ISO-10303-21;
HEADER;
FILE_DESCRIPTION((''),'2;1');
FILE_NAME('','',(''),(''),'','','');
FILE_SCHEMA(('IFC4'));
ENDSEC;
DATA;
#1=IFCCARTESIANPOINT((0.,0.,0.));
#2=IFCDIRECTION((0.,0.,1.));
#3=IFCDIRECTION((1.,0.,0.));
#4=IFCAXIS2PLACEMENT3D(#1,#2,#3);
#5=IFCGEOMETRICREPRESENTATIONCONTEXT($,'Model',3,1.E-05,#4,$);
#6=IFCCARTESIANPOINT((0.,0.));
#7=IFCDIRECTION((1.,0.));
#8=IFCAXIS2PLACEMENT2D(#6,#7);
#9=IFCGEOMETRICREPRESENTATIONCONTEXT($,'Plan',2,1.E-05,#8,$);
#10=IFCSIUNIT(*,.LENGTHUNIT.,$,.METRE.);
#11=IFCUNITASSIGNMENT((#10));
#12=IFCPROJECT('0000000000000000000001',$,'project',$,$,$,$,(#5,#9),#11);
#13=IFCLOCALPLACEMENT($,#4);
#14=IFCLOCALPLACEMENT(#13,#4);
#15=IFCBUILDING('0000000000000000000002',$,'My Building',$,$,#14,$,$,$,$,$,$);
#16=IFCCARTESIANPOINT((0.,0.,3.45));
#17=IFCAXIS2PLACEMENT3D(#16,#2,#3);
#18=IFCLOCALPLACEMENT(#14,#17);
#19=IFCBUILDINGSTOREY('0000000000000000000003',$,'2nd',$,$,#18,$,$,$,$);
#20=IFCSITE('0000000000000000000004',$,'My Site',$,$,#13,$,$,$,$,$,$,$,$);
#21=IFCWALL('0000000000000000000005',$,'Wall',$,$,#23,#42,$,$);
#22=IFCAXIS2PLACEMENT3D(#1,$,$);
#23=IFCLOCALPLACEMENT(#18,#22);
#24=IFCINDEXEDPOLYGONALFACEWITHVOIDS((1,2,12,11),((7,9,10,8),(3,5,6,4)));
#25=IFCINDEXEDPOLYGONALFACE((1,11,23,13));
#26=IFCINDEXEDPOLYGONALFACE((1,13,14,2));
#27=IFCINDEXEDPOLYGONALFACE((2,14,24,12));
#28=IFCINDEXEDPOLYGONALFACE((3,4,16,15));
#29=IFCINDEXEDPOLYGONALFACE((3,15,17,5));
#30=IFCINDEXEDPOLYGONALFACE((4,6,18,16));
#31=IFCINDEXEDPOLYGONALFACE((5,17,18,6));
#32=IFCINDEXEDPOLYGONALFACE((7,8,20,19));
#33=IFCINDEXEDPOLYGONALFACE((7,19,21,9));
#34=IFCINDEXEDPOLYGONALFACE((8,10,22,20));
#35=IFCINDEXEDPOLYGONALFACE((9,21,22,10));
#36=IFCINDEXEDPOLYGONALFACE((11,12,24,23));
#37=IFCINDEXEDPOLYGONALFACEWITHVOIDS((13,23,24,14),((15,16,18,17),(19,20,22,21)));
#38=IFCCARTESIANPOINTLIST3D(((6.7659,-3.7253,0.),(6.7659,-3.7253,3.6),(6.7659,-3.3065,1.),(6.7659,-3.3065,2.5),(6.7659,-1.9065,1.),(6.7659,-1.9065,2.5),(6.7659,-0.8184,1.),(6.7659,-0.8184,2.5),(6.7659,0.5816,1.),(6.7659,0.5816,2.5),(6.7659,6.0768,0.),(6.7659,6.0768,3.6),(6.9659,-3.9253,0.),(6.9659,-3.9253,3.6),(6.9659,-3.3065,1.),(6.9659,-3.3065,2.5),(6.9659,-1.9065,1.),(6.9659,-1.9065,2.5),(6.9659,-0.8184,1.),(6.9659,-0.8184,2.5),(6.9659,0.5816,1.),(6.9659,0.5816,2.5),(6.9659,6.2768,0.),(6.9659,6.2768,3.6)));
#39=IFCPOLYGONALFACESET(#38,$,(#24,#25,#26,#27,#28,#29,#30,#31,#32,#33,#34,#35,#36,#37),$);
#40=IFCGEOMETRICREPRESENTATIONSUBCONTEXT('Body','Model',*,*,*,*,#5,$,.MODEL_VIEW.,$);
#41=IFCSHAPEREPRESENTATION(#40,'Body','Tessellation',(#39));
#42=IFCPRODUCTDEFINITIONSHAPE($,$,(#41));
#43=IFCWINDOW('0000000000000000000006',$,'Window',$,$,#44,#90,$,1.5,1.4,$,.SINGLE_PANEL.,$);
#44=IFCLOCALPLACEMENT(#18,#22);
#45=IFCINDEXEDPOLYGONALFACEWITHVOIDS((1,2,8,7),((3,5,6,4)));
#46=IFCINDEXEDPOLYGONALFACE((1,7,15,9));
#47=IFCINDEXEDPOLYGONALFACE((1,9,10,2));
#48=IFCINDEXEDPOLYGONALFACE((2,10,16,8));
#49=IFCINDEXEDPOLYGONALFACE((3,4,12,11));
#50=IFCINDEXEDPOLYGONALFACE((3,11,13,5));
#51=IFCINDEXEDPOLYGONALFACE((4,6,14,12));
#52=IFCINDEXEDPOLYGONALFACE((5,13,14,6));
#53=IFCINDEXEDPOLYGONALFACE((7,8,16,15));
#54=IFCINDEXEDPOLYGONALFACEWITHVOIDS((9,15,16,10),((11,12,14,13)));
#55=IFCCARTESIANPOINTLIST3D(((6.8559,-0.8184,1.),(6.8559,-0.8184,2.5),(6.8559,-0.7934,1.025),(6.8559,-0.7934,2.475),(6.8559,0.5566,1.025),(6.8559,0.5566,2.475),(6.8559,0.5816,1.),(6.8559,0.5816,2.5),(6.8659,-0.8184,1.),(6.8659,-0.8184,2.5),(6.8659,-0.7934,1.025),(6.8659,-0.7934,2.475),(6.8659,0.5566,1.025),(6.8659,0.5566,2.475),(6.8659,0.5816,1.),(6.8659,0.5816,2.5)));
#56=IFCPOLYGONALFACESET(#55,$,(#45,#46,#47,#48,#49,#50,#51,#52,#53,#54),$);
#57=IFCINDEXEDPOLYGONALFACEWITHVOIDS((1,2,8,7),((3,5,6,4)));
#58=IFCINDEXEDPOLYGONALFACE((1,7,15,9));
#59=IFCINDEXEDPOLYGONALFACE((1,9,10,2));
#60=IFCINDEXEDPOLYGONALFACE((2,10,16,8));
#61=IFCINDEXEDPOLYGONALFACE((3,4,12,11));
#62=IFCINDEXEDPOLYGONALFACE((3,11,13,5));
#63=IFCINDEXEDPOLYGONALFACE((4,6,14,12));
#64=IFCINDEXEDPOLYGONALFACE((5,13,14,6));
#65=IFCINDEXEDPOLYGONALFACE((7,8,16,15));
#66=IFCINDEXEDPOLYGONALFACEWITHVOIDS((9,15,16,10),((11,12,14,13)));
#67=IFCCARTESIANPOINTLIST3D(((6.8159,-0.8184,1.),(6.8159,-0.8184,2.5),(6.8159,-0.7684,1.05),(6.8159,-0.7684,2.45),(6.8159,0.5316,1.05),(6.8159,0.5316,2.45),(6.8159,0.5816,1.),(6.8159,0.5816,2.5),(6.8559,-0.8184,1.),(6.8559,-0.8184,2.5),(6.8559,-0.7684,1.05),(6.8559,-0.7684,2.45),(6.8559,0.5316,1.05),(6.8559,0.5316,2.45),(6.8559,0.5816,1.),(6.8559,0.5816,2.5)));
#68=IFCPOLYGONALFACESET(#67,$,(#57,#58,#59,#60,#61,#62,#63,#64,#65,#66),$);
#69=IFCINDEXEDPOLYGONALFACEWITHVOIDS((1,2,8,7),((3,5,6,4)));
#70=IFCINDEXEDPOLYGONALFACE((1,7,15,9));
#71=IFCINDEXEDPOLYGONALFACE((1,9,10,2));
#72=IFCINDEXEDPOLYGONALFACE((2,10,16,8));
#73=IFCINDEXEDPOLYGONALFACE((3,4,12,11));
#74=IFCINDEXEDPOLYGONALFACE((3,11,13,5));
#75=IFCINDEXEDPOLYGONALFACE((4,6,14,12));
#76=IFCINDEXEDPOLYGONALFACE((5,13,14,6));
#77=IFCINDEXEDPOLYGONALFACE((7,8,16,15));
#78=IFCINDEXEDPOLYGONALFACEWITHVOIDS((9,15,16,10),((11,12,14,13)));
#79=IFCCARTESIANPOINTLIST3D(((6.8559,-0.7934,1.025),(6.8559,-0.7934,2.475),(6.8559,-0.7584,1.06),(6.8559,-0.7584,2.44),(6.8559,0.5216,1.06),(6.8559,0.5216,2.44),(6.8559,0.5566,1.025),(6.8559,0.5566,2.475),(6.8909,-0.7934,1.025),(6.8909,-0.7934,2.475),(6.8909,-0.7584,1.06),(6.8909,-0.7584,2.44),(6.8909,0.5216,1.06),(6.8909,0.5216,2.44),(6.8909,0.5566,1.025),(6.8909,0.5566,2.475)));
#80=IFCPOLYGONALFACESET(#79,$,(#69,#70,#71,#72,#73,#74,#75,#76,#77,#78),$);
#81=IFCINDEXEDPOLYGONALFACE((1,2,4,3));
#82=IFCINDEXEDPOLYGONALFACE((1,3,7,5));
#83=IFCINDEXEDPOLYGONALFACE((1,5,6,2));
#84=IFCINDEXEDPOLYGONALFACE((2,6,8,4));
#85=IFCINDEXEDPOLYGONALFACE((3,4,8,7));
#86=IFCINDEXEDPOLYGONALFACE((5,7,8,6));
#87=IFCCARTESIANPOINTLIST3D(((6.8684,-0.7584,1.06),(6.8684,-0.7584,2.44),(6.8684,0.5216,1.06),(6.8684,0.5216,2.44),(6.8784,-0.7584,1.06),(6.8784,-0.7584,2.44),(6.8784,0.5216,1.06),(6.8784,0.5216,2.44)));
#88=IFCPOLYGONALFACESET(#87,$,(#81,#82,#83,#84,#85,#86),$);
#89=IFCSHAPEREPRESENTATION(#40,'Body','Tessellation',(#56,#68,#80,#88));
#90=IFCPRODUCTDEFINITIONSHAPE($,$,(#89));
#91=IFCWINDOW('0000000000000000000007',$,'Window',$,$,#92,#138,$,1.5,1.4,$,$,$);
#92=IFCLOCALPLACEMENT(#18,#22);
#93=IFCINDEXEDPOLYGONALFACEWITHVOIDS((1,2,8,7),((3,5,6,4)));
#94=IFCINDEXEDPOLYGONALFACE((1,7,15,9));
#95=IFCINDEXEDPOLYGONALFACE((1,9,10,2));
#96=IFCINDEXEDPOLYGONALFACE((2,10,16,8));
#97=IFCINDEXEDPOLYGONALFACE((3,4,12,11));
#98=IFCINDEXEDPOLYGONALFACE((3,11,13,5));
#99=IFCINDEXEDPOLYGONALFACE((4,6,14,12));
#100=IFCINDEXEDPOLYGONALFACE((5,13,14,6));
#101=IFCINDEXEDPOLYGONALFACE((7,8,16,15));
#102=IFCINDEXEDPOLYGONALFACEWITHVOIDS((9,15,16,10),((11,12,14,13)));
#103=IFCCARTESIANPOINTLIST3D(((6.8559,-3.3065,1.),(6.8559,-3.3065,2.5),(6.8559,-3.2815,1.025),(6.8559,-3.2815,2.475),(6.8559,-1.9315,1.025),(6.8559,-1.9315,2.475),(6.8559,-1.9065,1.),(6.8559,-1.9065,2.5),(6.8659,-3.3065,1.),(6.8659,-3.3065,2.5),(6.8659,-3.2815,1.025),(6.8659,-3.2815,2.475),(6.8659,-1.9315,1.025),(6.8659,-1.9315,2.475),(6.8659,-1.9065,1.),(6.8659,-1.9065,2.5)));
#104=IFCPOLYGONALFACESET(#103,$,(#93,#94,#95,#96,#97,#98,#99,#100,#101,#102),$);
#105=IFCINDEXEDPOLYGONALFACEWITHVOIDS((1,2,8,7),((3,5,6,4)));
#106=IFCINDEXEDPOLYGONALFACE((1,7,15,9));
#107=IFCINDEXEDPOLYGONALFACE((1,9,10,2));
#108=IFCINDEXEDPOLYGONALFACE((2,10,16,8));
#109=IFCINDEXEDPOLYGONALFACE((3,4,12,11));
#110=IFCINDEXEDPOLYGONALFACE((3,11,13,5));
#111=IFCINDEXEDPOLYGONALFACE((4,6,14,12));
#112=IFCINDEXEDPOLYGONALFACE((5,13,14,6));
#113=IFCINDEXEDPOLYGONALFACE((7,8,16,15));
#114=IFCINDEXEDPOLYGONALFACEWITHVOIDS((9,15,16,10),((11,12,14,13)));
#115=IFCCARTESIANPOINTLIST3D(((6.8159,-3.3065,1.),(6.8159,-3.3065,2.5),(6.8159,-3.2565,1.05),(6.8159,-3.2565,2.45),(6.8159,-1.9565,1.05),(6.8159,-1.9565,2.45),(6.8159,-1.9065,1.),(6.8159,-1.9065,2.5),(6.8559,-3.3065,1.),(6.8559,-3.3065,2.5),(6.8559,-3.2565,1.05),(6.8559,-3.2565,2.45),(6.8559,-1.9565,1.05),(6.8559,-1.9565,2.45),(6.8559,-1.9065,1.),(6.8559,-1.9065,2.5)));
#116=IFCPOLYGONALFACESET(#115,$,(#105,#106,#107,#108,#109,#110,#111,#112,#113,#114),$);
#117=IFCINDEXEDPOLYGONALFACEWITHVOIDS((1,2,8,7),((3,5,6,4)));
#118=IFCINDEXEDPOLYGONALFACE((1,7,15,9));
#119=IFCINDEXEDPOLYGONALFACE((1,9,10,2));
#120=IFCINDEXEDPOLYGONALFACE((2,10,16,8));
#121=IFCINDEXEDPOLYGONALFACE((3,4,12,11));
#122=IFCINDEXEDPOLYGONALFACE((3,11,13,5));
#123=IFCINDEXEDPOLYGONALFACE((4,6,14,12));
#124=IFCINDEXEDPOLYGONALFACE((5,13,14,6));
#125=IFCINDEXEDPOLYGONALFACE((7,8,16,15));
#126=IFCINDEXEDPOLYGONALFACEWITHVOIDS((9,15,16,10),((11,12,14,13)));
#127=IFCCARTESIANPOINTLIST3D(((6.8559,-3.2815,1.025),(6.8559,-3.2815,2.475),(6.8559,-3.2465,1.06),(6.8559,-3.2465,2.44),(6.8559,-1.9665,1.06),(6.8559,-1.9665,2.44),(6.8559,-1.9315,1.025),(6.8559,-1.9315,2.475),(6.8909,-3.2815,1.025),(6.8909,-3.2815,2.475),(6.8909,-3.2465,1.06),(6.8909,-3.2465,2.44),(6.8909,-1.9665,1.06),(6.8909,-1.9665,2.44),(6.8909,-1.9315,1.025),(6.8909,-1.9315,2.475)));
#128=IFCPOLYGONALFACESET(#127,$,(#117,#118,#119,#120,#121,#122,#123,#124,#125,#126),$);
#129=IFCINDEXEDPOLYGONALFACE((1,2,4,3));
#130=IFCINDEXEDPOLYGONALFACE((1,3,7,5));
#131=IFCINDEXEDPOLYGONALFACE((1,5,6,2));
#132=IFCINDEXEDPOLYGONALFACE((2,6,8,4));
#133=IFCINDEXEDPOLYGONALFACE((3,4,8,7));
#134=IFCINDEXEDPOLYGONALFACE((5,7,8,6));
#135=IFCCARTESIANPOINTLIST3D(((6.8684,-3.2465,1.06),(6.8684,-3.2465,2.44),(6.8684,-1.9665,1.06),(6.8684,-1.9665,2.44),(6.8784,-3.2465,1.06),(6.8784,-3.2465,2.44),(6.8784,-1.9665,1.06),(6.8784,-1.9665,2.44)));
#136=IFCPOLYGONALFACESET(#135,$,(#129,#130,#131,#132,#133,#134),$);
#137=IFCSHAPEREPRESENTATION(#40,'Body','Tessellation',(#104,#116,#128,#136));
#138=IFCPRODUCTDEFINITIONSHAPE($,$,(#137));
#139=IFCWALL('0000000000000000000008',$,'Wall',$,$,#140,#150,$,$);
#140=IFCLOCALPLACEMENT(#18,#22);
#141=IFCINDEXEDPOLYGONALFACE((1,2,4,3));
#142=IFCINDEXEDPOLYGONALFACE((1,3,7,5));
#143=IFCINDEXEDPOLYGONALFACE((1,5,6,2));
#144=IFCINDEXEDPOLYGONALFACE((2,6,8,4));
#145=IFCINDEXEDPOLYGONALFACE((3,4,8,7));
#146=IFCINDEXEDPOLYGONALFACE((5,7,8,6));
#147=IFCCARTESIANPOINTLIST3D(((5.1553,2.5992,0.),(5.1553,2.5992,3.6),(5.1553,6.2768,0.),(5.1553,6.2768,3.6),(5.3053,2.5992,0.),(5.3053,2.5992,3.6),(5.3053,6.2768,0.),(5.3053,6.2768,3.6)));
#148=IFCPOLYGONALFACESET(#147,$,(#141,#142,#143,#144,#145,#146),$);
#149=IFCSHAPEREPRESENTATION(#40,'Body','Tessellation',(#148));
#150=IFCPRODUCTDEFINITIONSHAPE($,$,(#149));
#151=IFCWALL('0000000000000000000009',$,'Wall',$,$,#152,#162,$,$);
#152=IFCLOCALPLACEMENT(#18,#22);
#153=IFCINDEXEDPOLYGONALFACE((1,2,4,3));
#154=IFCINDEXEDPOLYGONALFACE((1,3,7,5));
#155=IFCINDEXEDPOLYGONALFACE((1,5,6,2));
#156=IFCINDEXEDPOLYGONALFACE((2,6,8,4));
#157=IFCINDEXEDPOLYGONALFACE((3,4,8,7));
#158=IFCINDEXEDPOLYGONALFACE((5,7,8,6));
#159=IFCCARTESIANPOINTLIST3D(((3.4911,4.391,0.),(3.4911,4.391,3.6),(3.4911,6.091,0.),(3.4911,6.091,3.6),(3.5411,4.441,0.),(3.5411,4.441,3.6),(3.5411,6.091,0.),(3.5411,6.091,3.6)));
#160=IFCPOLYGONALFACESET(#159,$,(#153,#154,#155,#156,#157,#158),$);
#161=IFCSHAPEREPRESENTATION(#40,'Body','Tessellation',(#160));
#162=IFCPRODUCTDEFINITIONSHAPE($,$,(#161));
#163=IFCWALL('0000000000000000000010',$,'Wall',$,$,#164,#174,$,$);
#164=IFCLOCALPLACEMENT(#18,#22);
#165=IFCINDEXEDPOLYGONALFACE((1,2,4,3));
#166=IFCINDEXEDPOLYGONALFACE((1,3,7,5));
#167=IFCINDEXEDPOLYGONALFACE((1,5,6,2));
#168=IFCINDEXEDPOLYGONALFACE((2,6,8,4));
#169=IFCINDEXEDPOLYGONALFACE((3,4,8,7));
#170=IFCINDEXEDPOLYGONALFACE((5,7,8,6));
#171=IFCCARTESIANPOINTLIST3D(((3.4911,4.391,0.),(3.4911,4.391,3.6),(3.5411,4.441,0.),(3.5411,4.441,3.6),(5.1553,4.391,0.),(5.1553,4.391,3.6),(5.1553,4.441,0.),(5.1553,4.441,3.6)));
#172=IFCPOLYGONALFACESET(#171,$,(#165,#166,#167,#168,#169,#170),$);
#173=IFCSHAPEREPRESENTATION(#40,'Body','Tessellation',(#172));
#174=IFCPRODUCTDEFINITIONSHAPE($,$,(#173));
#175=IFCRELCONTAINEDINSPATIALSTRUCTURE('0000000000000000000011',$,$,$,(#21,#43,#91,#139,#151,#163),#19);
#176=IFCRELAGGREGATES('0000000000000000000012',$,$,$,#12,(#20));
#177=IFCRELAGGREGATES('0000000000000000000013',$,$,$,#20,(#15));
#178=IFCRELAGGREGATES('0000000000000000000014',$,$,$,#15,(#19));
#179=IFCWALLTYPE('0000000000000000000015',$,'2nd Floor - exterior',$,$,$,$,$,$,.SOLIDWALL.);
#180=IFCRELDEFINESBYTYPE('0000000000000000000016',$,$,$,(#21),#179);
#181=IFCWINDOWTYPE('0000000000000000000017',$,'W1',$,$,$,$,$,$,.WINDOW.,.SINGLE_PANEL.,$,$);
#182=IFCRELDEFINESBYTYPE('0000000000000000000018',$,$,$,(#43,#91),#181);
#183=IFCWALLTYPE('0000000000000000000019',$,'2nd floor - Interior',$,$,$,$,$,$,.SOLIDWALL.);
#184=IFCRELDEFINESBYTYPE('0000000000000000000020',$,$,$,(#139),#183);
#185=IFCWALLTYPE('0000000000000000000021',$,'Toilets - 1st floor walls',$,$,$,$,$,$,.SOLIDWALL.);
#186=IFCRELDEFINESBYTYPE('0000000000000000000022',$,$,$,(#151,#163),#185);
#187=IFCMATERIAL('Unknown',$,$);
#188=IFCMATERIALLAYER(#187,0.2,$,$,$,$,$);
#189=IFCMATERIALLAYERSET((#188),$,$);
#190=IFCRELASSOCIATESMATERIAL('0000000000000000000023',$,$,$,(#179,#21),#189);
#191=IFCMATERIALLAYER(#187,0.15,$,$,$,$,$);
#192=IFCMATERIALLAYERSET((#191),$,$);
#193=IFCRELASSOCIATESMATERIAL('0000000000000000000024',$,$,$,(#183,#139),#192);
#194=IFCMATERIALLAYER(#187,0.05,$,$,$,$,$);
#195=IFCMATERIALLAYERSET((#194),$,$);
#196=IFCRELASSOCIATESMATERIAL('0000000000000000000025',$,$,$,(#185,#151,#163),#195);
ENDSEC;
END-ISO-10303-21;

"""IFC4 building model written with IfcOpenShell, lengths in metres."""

from ifc_helpers import new_model, entity, si_unit, frame, origin_with_axes, origin_2d_with_axis, place, context, subcontext, project, spatial, line, indexed_curve, outline, extrude, shape, source, transform, mapped, material, layer, layer_set, layer_usage, type_object, type_shapes, element, fill, save


model = new_model("IFC4")

# Units and contexts
model_context = context("Model", 3, precision=1e-05, world=origin_with_axes())
plan_context = context("Plan", 2, precision=1e-05, world=origin_2d_with_axis())
body_context_1 = subcontext(model_context, "Body", "Model", "MODEL_VIEW")
body_context_2 = subcontext(plan_context, "Body", "Plan", "PLAN_VIEW")
ifc_project = project(units=[si_unit("LENGTHUNIT", "METRE")], contexts=[model_context, plan_context])

# Site, building, storey
site_placement = place(None, origin_with_axes())
site = spatial("IfcSite", under=ifc_project, at=site_placement, Name="My Site")
building_placement = place(site_placement, origin_with_axes())
building = spatial("IfcBuilding", under=site, at=building_placement, Name="My Building")
storey_placement = place(building_placement, frame((0.0, 0.0, 3.45), z_axis=(0.0, 0.0, 1.0), x_axis=(1.0, 0.0, 0.0)))
storey = spatial("IfcBuildingStorey", under=building, at=storey_placement, Name="2nd")

# Shared definitions
ifc_material = material(Name="Unknown")

# Shared definitions
window_type_1 = type_object("IfcWindowType", Name="W1", PartitioningType="SINGLE_PANEL", PredefinedType="WINDOW")
shared_shape_1 = source(origin_with_axes(), body_context_1, "Body", "SweptSolid", [
    extrude(outline(indexed_curve([(0.0, 0.0), (1.4, 0.0), (1.4, 1.5), (0.0, 1.5)], segments=[line(1, 2, 3, 4, 1)]), holes=[indexed_curve([(0.025, 0.025), (1.375, 0.025), (1.375, 1.475), (0.025, 1.475)], segments=[line(1, 2, 3, 4, 1)])]), frame((0.0, 0.09, 0.0), z_axis=(0.0, -1.0, 0.0), x_axis=(1.0, 0.0, 0.0)), (0.0, 0.0, -1.0), 0.01),
    extrude(outline(indexed_curve([(0.0, 0.0), (1.4, 0.0), (1.4, 1.5), (0.0, 1.5)], segments=[line(1, 2, 3, 4, 1)]), holes=[indexed_curve([(0.05, 0.05), (1.35, 0.05), (1.35, 1.45), (0.05, 1.45)], segments=[line(1, 2, 3, 4, 1)])]), frame((0.0, 0.05, 0.0), z_axis=(0.0, -1.0, 0.0), x_axis=(1.0, 0.0, 0.0)), (0.0, 0.0, -1.0), 0.04),
    extrude(outline(indexed_curve([(0.0, 0.0), (1.35, 0.0), (1.35, 1.45), (0.0, 1.45)], segments=[line(1, 2, 3, 4, 1)]), holes=[indexed_curve([(0.035, 0.035), (1.315, 0.035), (1.315, 1.415), (0.035, 1.415)], segments=[line(1, 2, 3, 4, 1)])]), frame((0.025, 0.09, 0.025), z_axis=(0.0, -1.0, 0.0), x_axis=(1.0, 0.0, 0.0)), (0.0, 0.0, -1.0), 0.035),
    extrude(outline(indexed_curve([(0.035, 0.035), (1.315, 0.035), (1.315, 1.415), (0.035, 1.415)], segments=[line(1, 2, 3, 4, 1)])), frame((0.025, 0.1025, 0.025), z_axis=(0.0, -1.0, 0.0), x_axis=(1.0, 0.0, 0.0)), (0.0, 0.0, -1.0), 0.01),
])
shared_shape_2 = source(origin_with_axes(), body_context_2, "Body", "Curve2D", [
    entity("IfcIndexedPolyCurve", entity("IfcCartesianPointList2D", [[0.05, 0.05], [1.35, 0.05]])),
    entity("IfcIndexedPolyCurve", entity("IfcCartesianPointList2D", [[0.0, 0.1], [0.025, 0.1], [0.025, 0.09], [0.05, 0.09], [0.05, 0.05], [0.0, 0.05]]), [entity("IfcLineIndex", [1, 2, 3, 4, 5, 6, 1])]),
    entity("IfcIndexedPolyCurve", entity("IfcCartesianPointList2D", [[1.4, 0.1], [1.375, 0.1], [1.375, 0.09], [1.35, 0.09], [1.35, 0.05], [1.4, 0.05]]), [entity("IfcLineIndex", [1, 2, 3, 4, 5, 6, 1])]),
    entity("IfcIndexedPolyCurve", entity("IfcCartesianPointList2D", [[0.025, 0.09], [0.06, 0.09], [0.06, 0.125], [0.025, 0.125]]), [entity("IfcLineIndex", [1, 2, 3, 4, 1])]),
    entity("IfcIndexedPolyCurve", entity("IfcCartesianPointList2D", [[1.375, 0.09], [1.34, 0.09], [1.34, 0.125], [1.375, 0.125]]), [entity("IfcLineIndex", [1, 2, 3, 4, 1])]),
    entity("IfcIndexedPolyCurve", entity("IfcCartesianPointList2D", [[0.06, 0.09], [1.34, 0.09]])),
    entity("IfcIndexedPolyCurve", entity("IfcCartesianPointList2D", [[0.06, 0.125], [1.34, 0.125]])),
    entity("IfcIndexedPolyCurve", entity("IfcCartesianPointList2D", [[0.06, 0.1075], [1.34, 0.1075]])),
])
type_shapes(window_type_1, [shared_shape_1, shared_shape_2])
wall_1_placement = place(storey_placement, frame((6.9659, -3.9253, 0.0), z_axis=(0.0, 0.0, 1.0), x_axis=(0.0, 1.0, 0.0)))
opening_1_placement = place(wall_1_placement, frame((4.5069, 0.2, 1.0), z_axis=(0.0, 0.0, 1.0), x_axis=(-1.0, 0.0, 0.0)))

# Wall, openings, windows
ifc_layer_1 = layer(ifc_material, 0.2)
ifc_layer_set_1 = layer_set([ifc_layer_1])
ifc_layer_usage_1 = layer_usage(ifc_layer_set_1, "AXIS2", "POSITIVE", 0.0)
wall_type_1 = type_object("IfcWallType", Name="2nd Floor - exterior", PredefinedType="SOLIDWALL", material=ifc_layer_set_1)
wall_1 = element("IfcWall", 1, at=wall_1_placement, inside=storey, type_object=wall_type_1, material=ifc_layer_usage_1, Name="Wall", context=body_context_1, shape_type="SweptSolid", body=[
    extrude(outline(indexed_curve([(0.0, 0.0), (0.2, 0.2), (10.0021, 0.2), (10.2021, 0.0)], segments=[line(1, 2, 3, 4, 1)])), origin_with_axes(), (0.0, 0.0, 1.0), 3.6),
])
shared_shape_3 = source(origin_with_axes(), body_context_1, "Body", "SweptSolid", [
    extrude(outline(indexed_curve([(0.0, 0.0), (1.4, 0.0), (1.4, 1.5), (0.0, 1.5)], segments=[line(1, 2, 3, 4, 1)])), frame((0.0, -0.6, 0.0), z_axis=(0.0, -1.0, 0.0), x_axis=(1.0, 0.0, 0.0)), (0.0, 0.0, -1.0), 1.2),
])
opening_1 = element("IfcOpeningElement", 2, at=opening_1_placement, cuts=wall_1, PredefinedType="OPENING", context=body_context_1, shape_type="MappedRepresentation", body=[
    mapped(shared_shape_3, transform((0.0, 0.0, 0.0), x_axis=(1.0, 0.0, 0.0), y_axis=(0.0, 1.0, 0.0), z_axis=(0.0, 0.0, 1.0), scale=1.0)),
])
opening_2_placement = place(wall_1_placement, frame((2.0187, 0.2, 1.0), z_axis=(0.0, 0.0, 1.0), x_axis=(-1.0, 0.0, 0.0)))
opening_2 = element("IfcOpeningElement", 3, at=opening_2_placement, cuts=wall_1, PredefinedType="OPENING", context=body_context_1, shape_type="MappedRepresentation", body=[
    mapped(shared_shape_3, transform((0.0, 0.0, 0.0), x_axis=(1.0, 0.0, 0.0), y_axis=(0.0, 1.0, 0.0), z_axis=(0.0, 0.0, 1.0), scale=1.0)),
])
window_1_placement = place(opening_1_placement, frame((0.0, 0.0, 0.0), z_axis=(0.0, 0.0, 1.0), x_axis=(1.0, 0.0, 0.0)))
window_1 = element("IfcWindow", 4, at=window_1_placement, inside=storey, type_object=window_type_1, Name="Window", OverallHeight=1.5, OverallWidth=1.4, PartitioningType="SINGLE_PANEL", shapes=[
    shape(body_context_1, "Body", "MappedRepresentation", [mapped(shared_shape_1, transform((0.0, 0.0, 0.0), x_axis=(1.0, 0.0, 0.0), y_axis=(0.0, 1.0, 0.0), z_axis=(0.0, 0.0, 1.0), scale=1.0))]),
    shape(body_context_2, "Body", "MappedRepresentation", [mapped(shared_shape_2, transform((0.0, 0.0, 0.0), x_axis=(1.0, 0.0, 0.0), y_axis=(0.0, 1.0, 0.0), z_axis=(0.0, 0.0, 1.0), scale=1.0))]),
])
fill(opening_1, window_1)
window_2_placement = place(opening_2_placement, origin_with_axes())
window_2 = element("IfcWindow", 5, at=window_2_placement, inside=storey, type_object=window_type_1, Name="Window", OverallHeight=1.5, OverallWidth=1.4, shapes=[
    shape(body_context_1, "Body", "MappedRepresentation", [mapped(shared_shape_1, transform((0.0, 0.0, 0.0), x_axis=(1.0, 0.0, 0.0), y_axis=(0.0, 1.0, 0.0), z_axis=(0.0, 0.0, 1.0), scale=1.0))]),
    shape(body_context_2, "Body", "MappedRepresentation", [mapped(shared_shape_2, transform((0.0, 0.0, 0.0), x_axis=(1.0, 0.0, 0.0), y_axis=(0.0, 1.0, 0.0), z_axis=(0.0, 0.0, 1.0), scale=1.0))]),
])
fill(opening_2, window_2)

# Shared definitions
ifc_layer_2 = layer(ifc_material, 0.15)
ifc_layer_set_2 = layer_set([ifc_layer_2])
wall_type_2 = type_object("IfcWallType", Name="2nd floor - Interior", PredefinedType="SOLIDWALL", material=ifc_layer_set_2)

# Wall
ifc_layer_usage_2 = layer_usage(ifc_layer_set_2, "AXIS2", "POSITIVE", 0.0)
wall_2_placement = place(storey_placement, frame((5.1553, 6.2768, 0.0), z_axis=(0.0, 0.0, 1.0), x_axis=(0.0, -1.0, 0.0)))
element("IfcWall", 6, at=wall_2_placement, inside=storey, type_object=wall_type_2, material=ifc_layer_usage_2, Name="Wall", context=body_context_1, shape_type="SweptSolid", body=[
    extrude(outline(indexed_curve([(0.0, 0.0), (0.0, 0.15), (3.6776, 0.15), (3.6776, 0.0)], segments=[line(1, 2, 3, 4, 1)])), origin_with_axes(), (0.0, 0.0, 1.0), 3.6),
])
ifc_layer_3 = layer(ifc_material, 0.05)
ifc_layer_set_3 = layer_set([ifc_layer_3])
wall_type_3 = type_object("IfcWallType", Name="Toilets - 1st floor walls", PredefinedType="SOLIDWALL", material=ifc_layer_set_3)

# Walls
ifc_layer_usage_3 = layer_usage(ifc_layer_set_3, "AXIS2", "POSITIVE", 0.0)
wall_3_placement = place(storey_placement, frame((3.4911, 6.091, 0.0), z_axis=(0.0, 0.0, 1.0), x_axis=(0.0, -1.0, 0.0)))
element("IfcWall", 7, at=wall_3_placement, inside=storey, type_object=wall_type_3, material=ifc_layer_usage_3, Name="Wall", context=body_context_1, shape_type="SweptSolid", body=[
    extrude(outline(indexed_curve([(0.0, 0.0), (0.0, 0.05), (1.65, 0.05), (1.7, 0.0)], segments=[line(1, 2, 3, 4, 1)])), origin_with_axes(), (0.0, 0.0, 1.0), 3.6),
])
ifc_layer_usage_4 = layer_usage(ifc_layer_set_3, "AXIS2", "POSITIVE", 0.0)
wall_4_placement = place(storey_placement, frame((3.4911, 4.391, 0.0), z_axis=(0.0, 0.0, 1.0), x_axis=(1.0, 0.0, 0.0)))
element("IfcWall", 8, at=wall_4_placement, inside=storey, type_object=wall_type_3, material=ifc_layer_usage_4, Name="Wall", context=body_context_1, shape_type="SweptSolid", body=[
    extrude(outline(indexed_curve([(0.0, 0.0), (0.05, 0.05), (1.6642, 0.05), (1.6642, 0.0)], segments=[line(1, 2, 3, 4, 1)])), origin_with_axes(), (0.0, 0.0, 1.0), 3.6),
])

save(model, "model.ifc")
